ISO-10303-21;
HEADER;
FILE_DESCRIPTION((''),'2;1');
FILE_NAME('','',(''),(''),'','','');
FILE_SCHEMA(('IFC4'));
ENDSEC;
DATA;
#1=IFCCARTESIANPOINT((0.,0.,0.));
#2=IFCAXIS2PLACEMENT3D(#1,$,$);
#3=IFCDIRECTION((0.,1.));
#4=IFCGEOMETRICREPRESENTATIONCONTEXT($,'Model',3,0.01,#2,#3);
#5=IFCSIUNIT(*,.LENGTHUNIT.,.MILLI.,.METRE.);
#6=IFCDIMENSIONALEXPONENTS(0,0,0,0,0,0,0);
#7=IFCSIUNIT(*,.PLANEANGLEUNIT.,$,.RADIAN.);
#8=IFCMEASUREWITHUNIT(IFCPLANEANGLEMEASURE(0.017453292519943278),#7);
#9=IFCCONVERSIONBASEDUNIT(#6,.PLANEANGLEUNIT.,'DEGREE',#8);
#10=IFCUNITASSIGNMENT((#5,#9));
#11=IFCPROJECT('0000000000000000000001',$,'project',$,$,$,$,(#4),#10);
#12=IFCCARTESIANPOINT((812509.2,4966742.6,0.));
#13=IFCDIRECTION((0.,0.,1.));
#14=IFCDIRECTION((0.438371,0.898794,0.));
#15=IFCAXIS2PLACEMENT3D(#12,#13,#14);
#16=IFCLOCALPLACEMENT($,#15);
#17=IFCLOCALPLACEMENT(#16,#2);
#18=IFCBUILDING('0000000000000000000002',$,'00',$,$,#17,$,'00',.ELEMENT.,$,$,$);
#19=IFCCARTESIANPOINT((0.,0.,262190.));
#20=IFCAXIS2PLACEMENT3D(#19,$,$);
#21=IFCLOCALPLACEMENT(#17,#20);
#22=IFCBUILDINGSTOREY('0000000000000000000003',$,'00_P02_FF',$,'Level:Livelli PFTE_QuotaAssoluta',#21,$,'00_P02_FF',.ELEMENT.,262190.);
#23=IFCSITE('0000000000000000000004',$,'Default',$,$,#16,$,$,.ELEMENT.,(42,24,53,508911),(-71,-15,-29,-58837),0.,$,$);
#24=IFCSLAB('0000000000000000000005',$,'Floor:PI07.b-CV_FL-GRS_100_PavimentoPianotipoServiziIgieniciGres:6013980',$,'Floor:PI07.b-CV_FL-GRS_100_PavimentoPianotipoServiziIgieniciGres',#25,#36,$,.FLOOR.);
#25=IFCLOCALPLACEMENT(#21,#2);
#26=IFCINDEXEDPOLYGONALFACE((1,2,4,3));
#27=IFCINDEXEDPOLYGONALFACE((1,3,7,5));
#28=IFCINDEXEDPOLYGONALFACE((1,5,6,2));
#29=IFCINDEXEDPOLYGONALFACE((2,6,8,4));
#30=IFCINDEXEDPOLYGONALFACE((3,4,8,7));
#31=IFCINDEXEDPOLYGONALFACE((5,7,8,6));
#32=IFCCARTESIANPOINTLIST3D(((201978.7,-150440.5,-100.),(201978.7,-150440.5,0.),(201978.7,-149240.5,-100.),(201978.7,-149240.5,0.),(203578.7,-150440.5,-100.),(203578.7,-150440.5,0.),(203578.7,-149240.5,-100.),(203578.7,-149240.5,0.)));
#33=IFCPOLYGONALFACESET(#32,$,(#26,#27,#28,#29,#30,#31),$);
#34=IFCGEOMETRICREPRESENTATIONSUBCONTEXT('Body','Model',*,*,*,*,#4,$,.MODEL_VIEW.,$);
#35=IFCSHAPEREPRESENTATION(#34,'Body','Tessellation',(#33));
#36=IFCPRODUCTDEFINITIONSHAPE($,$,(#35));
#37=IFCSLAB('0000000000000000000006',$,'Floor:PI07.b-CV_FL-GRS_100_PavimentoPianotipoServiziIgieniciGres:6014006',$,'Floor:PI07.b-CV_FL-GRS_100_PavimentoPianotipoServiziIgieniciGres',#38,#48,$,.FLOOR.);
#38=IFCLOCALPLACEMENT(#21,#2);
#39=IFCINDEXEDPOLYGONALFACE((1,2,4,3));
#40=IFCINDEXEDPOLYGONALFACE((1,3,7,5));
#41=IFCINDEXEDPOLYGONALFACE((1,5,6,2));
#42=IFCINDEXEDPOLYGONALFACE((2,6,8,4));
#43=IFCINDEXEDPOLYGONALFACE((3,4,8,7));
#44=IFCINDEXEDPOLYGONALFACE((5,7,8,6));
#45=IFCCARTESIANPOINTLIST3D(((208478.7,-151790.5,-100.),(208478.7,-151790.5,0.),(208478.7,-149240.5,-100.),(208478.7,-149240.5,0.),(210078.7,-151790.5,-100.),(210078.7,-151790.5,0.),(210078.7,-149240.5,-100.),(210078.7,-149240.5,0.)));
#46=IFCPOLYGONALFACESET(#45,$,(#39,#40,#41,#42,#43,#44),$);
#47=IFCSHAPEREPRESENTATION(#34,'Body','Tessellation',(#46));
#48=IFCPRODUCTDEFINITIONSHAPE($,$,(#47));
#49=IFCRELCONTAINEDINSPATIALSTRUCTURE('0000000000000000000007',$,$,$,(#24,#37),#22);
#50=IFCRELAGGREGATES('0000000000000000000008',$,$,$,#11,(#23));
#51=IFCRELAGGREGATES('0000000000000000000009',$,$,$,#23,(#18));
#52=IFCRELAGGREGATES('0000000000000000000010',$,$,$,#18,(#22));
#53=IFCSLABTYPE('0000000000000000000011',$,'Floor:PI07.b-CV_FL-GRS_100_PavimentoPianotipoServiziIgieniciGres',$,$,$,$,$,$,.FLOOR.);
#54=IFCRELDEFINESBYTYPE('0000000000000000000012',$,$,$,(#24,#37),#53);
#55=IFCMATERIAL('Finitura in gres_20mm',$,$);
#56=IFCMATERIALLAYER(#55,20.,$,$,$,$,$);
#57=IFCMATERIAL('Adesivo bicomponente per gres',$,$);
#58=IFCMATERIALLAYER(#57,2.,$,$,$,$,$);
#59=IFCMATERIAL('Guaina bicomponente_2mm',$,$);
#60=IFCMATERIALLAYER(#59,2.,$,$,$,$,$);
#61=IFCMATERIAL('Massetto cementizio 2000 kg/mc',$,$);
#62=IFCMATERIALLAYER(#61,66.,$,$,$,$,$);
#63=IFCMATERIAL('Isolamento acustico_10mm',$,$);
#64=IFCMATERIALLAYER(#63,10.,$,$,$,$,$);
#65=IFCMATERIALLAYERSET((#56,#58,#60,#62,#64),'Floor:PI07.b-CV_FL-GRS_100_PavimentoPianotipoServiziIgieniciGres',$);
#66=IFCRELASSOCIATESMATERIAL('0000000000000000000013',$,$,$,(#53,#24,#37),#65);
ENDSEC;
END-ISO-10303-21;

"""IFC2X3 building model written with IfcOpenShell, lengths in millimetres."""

from ifc_helpers import new_model, entity, si_unit, converted_unit, direction, frame, frame_2d, origin, place, context, subcontext, project, spatial, rectangle, extrude, material, layer, layer_set, layer_usage, type_object, element, save


model = new_model("IFC2X3")

# Units and contexts
model_context = context("Model", 3, precision=0.01, world=origin(), true_north=direction((0.0, 1.0)))
body_context = subcontext(model_context, "Body", "Model", "MODEL_VIEW")
ifc_project = project(units=[si_unit("LENGTHUNIT", "METRE", prefix="MILLI"), converted_unit("PLANEANGLEUNIT", "DEGREE", entity("IfcPlaneAngleMeasure", 0.017453292519943278), si_unit("PLANEANGLEUNIT", "RADIAN"), dimensions=[0, 0, 0, 0, 0, 0, 0])], contexts=[model_context])

# Site, building, storey
site_placement = place(None, frame((812509.2, 4966742.6, 0.0), z_axis=(0.0, 0.0, 1.0), x_axis=(0.438371, 0.898794, 0.0)))
site = spatial("IfcSite", under=ifc_project, at=site_placement, Name="Default", CompositionType="ELEMENT", RefLatitude=(42, 24, 53, 508911), RefLongitude=(-71, -15, -29, -58837), RefElevation=0.0)
building_placement = place(site_placement, origin())
building = spatial("IfcBuilding", under=site, at=building_placement, Name="00", LongName="00", CompositionType="ELEMENT")
storey_placement = place(building_placement, frame((0.0, 0.0, 262190.0)))
storey = spatial("IfcBuildingStorey", under=building, at=storey_placement, Name="00_P02_FF", ObjectType="Level:Livelli PFTE_QuotaAssoluta", LongName="00_P02_FF", CompositionType="ELEMENT", Elevation=262190.0)

# Slabs
ifc_material_1 = material(Name="Massetto cementizio 2000 kg/mc")
ifc_material_2 = material(Name="Isolamento acustico_10mm")
ifc_material_3 = material(Name="Finitura in gres_20mm")
ifc_layer_1 = layer(ifc_material_3, 20.0)
ifc_material_4 = material(Name="Adesivo bicomponente per gres")
ifc_layer_2 = layer(ifc_material_4, 2.0)
ifc_material_5 = material(Name="Guaina bicomponente_2mm")
ifc_layer_3 = layer(ifc_material_5, 2.0)
ifc_layer_4 = layer(ifc_material_1, 66.0)
ifc_layer_5 = layer(ifc_material_2, 10.0)
ifc_layer_set_1 = layer_set([ifc_layer_1, ifc_layer_2, ifc_layer_3, ifc_layer_4, ifc_layer_5], Name="Floor:PI07.b-CV_FL-GRS_100_PavimentoPianotipoServiziIgieniciGres")
slab_type_1 = type_object("IfcSlabType", Name="Floor:PI07.b-CV_FL-GRS_100_PavimentoPianotipoServiziIgieniciGres", PredefinedType="FLOOR", material=ifc_layer_set_1)
ifc_layer_usage_1 = layer_usage(ifc_layer_set_1, "AXIS3", "POSITIVE", 0.0)
slab_1_placement = place(storey_placement, origin())
element("IfcSlab", 1, at=slab_1_placement, inside=storey, type_object=slab_type_1, material=ifc_layer_usage_1, Name="Floor:PI07.b-CV_FL-GRS_100_PavimentoPianotipoServiziIgieniciGres:6013980", ObjectType="Floor:PI07.b-CV_FL-GRS_100_PavimentoPianotipoServiziIgieniciGres", PredefinedType="FLOOR", context=body_context, shape_type="SweptSolid", body=[
    extrude(rectangle(XDim=1200.0, YDim=1600.0, at=frame_2d((0.0, 0.0), x_axis=(1.0, 0.0))), frame((202778.7, -149840.5, 0.0), z_axis=(0.0, 0.0, -1.0), x_axis=(0.0, 1.0, 0.0)), (0.0, 0.0, 1.0), 100.0),
])
ifc_layer_usage_2 = layer_usage(ifc_layer_set_1, "AXIS3", "POSITIVE", 0.0)
slab_2_placement = place(storey_placement, origin())
element("IfcSlab", 2, at=slab_2_placement, inside=storey, type_object=slab_type_1, material=ifc_layer_usage_2, Name="Floor:PI07.b-CV_FL-GRS_100_PavimentoPianotipoServiziIgieniciGres:6014006", ObjectType="Floor:PI07.b-CV_FL-GRS_100_PavimentoPianotipoServiziIgieniciGres", PredefinedType="FLOOR", context=body_context, shape_type="SweptSolid", body=[
    extrude(rectangle(XDim=2550.0, YDim=1600.0, at=frame_2d((0.0, 0.0), x_axis=(1.0, 0.0))), frame((209278.7, -150515.5, 0.0), z_axis=(0.0, 0.0, -1.0), x_axis=(0.0, 1.0, 0.0)), (0.0, 0.0, 1.0), 100.0),
])

save(model, "model.ifc")
